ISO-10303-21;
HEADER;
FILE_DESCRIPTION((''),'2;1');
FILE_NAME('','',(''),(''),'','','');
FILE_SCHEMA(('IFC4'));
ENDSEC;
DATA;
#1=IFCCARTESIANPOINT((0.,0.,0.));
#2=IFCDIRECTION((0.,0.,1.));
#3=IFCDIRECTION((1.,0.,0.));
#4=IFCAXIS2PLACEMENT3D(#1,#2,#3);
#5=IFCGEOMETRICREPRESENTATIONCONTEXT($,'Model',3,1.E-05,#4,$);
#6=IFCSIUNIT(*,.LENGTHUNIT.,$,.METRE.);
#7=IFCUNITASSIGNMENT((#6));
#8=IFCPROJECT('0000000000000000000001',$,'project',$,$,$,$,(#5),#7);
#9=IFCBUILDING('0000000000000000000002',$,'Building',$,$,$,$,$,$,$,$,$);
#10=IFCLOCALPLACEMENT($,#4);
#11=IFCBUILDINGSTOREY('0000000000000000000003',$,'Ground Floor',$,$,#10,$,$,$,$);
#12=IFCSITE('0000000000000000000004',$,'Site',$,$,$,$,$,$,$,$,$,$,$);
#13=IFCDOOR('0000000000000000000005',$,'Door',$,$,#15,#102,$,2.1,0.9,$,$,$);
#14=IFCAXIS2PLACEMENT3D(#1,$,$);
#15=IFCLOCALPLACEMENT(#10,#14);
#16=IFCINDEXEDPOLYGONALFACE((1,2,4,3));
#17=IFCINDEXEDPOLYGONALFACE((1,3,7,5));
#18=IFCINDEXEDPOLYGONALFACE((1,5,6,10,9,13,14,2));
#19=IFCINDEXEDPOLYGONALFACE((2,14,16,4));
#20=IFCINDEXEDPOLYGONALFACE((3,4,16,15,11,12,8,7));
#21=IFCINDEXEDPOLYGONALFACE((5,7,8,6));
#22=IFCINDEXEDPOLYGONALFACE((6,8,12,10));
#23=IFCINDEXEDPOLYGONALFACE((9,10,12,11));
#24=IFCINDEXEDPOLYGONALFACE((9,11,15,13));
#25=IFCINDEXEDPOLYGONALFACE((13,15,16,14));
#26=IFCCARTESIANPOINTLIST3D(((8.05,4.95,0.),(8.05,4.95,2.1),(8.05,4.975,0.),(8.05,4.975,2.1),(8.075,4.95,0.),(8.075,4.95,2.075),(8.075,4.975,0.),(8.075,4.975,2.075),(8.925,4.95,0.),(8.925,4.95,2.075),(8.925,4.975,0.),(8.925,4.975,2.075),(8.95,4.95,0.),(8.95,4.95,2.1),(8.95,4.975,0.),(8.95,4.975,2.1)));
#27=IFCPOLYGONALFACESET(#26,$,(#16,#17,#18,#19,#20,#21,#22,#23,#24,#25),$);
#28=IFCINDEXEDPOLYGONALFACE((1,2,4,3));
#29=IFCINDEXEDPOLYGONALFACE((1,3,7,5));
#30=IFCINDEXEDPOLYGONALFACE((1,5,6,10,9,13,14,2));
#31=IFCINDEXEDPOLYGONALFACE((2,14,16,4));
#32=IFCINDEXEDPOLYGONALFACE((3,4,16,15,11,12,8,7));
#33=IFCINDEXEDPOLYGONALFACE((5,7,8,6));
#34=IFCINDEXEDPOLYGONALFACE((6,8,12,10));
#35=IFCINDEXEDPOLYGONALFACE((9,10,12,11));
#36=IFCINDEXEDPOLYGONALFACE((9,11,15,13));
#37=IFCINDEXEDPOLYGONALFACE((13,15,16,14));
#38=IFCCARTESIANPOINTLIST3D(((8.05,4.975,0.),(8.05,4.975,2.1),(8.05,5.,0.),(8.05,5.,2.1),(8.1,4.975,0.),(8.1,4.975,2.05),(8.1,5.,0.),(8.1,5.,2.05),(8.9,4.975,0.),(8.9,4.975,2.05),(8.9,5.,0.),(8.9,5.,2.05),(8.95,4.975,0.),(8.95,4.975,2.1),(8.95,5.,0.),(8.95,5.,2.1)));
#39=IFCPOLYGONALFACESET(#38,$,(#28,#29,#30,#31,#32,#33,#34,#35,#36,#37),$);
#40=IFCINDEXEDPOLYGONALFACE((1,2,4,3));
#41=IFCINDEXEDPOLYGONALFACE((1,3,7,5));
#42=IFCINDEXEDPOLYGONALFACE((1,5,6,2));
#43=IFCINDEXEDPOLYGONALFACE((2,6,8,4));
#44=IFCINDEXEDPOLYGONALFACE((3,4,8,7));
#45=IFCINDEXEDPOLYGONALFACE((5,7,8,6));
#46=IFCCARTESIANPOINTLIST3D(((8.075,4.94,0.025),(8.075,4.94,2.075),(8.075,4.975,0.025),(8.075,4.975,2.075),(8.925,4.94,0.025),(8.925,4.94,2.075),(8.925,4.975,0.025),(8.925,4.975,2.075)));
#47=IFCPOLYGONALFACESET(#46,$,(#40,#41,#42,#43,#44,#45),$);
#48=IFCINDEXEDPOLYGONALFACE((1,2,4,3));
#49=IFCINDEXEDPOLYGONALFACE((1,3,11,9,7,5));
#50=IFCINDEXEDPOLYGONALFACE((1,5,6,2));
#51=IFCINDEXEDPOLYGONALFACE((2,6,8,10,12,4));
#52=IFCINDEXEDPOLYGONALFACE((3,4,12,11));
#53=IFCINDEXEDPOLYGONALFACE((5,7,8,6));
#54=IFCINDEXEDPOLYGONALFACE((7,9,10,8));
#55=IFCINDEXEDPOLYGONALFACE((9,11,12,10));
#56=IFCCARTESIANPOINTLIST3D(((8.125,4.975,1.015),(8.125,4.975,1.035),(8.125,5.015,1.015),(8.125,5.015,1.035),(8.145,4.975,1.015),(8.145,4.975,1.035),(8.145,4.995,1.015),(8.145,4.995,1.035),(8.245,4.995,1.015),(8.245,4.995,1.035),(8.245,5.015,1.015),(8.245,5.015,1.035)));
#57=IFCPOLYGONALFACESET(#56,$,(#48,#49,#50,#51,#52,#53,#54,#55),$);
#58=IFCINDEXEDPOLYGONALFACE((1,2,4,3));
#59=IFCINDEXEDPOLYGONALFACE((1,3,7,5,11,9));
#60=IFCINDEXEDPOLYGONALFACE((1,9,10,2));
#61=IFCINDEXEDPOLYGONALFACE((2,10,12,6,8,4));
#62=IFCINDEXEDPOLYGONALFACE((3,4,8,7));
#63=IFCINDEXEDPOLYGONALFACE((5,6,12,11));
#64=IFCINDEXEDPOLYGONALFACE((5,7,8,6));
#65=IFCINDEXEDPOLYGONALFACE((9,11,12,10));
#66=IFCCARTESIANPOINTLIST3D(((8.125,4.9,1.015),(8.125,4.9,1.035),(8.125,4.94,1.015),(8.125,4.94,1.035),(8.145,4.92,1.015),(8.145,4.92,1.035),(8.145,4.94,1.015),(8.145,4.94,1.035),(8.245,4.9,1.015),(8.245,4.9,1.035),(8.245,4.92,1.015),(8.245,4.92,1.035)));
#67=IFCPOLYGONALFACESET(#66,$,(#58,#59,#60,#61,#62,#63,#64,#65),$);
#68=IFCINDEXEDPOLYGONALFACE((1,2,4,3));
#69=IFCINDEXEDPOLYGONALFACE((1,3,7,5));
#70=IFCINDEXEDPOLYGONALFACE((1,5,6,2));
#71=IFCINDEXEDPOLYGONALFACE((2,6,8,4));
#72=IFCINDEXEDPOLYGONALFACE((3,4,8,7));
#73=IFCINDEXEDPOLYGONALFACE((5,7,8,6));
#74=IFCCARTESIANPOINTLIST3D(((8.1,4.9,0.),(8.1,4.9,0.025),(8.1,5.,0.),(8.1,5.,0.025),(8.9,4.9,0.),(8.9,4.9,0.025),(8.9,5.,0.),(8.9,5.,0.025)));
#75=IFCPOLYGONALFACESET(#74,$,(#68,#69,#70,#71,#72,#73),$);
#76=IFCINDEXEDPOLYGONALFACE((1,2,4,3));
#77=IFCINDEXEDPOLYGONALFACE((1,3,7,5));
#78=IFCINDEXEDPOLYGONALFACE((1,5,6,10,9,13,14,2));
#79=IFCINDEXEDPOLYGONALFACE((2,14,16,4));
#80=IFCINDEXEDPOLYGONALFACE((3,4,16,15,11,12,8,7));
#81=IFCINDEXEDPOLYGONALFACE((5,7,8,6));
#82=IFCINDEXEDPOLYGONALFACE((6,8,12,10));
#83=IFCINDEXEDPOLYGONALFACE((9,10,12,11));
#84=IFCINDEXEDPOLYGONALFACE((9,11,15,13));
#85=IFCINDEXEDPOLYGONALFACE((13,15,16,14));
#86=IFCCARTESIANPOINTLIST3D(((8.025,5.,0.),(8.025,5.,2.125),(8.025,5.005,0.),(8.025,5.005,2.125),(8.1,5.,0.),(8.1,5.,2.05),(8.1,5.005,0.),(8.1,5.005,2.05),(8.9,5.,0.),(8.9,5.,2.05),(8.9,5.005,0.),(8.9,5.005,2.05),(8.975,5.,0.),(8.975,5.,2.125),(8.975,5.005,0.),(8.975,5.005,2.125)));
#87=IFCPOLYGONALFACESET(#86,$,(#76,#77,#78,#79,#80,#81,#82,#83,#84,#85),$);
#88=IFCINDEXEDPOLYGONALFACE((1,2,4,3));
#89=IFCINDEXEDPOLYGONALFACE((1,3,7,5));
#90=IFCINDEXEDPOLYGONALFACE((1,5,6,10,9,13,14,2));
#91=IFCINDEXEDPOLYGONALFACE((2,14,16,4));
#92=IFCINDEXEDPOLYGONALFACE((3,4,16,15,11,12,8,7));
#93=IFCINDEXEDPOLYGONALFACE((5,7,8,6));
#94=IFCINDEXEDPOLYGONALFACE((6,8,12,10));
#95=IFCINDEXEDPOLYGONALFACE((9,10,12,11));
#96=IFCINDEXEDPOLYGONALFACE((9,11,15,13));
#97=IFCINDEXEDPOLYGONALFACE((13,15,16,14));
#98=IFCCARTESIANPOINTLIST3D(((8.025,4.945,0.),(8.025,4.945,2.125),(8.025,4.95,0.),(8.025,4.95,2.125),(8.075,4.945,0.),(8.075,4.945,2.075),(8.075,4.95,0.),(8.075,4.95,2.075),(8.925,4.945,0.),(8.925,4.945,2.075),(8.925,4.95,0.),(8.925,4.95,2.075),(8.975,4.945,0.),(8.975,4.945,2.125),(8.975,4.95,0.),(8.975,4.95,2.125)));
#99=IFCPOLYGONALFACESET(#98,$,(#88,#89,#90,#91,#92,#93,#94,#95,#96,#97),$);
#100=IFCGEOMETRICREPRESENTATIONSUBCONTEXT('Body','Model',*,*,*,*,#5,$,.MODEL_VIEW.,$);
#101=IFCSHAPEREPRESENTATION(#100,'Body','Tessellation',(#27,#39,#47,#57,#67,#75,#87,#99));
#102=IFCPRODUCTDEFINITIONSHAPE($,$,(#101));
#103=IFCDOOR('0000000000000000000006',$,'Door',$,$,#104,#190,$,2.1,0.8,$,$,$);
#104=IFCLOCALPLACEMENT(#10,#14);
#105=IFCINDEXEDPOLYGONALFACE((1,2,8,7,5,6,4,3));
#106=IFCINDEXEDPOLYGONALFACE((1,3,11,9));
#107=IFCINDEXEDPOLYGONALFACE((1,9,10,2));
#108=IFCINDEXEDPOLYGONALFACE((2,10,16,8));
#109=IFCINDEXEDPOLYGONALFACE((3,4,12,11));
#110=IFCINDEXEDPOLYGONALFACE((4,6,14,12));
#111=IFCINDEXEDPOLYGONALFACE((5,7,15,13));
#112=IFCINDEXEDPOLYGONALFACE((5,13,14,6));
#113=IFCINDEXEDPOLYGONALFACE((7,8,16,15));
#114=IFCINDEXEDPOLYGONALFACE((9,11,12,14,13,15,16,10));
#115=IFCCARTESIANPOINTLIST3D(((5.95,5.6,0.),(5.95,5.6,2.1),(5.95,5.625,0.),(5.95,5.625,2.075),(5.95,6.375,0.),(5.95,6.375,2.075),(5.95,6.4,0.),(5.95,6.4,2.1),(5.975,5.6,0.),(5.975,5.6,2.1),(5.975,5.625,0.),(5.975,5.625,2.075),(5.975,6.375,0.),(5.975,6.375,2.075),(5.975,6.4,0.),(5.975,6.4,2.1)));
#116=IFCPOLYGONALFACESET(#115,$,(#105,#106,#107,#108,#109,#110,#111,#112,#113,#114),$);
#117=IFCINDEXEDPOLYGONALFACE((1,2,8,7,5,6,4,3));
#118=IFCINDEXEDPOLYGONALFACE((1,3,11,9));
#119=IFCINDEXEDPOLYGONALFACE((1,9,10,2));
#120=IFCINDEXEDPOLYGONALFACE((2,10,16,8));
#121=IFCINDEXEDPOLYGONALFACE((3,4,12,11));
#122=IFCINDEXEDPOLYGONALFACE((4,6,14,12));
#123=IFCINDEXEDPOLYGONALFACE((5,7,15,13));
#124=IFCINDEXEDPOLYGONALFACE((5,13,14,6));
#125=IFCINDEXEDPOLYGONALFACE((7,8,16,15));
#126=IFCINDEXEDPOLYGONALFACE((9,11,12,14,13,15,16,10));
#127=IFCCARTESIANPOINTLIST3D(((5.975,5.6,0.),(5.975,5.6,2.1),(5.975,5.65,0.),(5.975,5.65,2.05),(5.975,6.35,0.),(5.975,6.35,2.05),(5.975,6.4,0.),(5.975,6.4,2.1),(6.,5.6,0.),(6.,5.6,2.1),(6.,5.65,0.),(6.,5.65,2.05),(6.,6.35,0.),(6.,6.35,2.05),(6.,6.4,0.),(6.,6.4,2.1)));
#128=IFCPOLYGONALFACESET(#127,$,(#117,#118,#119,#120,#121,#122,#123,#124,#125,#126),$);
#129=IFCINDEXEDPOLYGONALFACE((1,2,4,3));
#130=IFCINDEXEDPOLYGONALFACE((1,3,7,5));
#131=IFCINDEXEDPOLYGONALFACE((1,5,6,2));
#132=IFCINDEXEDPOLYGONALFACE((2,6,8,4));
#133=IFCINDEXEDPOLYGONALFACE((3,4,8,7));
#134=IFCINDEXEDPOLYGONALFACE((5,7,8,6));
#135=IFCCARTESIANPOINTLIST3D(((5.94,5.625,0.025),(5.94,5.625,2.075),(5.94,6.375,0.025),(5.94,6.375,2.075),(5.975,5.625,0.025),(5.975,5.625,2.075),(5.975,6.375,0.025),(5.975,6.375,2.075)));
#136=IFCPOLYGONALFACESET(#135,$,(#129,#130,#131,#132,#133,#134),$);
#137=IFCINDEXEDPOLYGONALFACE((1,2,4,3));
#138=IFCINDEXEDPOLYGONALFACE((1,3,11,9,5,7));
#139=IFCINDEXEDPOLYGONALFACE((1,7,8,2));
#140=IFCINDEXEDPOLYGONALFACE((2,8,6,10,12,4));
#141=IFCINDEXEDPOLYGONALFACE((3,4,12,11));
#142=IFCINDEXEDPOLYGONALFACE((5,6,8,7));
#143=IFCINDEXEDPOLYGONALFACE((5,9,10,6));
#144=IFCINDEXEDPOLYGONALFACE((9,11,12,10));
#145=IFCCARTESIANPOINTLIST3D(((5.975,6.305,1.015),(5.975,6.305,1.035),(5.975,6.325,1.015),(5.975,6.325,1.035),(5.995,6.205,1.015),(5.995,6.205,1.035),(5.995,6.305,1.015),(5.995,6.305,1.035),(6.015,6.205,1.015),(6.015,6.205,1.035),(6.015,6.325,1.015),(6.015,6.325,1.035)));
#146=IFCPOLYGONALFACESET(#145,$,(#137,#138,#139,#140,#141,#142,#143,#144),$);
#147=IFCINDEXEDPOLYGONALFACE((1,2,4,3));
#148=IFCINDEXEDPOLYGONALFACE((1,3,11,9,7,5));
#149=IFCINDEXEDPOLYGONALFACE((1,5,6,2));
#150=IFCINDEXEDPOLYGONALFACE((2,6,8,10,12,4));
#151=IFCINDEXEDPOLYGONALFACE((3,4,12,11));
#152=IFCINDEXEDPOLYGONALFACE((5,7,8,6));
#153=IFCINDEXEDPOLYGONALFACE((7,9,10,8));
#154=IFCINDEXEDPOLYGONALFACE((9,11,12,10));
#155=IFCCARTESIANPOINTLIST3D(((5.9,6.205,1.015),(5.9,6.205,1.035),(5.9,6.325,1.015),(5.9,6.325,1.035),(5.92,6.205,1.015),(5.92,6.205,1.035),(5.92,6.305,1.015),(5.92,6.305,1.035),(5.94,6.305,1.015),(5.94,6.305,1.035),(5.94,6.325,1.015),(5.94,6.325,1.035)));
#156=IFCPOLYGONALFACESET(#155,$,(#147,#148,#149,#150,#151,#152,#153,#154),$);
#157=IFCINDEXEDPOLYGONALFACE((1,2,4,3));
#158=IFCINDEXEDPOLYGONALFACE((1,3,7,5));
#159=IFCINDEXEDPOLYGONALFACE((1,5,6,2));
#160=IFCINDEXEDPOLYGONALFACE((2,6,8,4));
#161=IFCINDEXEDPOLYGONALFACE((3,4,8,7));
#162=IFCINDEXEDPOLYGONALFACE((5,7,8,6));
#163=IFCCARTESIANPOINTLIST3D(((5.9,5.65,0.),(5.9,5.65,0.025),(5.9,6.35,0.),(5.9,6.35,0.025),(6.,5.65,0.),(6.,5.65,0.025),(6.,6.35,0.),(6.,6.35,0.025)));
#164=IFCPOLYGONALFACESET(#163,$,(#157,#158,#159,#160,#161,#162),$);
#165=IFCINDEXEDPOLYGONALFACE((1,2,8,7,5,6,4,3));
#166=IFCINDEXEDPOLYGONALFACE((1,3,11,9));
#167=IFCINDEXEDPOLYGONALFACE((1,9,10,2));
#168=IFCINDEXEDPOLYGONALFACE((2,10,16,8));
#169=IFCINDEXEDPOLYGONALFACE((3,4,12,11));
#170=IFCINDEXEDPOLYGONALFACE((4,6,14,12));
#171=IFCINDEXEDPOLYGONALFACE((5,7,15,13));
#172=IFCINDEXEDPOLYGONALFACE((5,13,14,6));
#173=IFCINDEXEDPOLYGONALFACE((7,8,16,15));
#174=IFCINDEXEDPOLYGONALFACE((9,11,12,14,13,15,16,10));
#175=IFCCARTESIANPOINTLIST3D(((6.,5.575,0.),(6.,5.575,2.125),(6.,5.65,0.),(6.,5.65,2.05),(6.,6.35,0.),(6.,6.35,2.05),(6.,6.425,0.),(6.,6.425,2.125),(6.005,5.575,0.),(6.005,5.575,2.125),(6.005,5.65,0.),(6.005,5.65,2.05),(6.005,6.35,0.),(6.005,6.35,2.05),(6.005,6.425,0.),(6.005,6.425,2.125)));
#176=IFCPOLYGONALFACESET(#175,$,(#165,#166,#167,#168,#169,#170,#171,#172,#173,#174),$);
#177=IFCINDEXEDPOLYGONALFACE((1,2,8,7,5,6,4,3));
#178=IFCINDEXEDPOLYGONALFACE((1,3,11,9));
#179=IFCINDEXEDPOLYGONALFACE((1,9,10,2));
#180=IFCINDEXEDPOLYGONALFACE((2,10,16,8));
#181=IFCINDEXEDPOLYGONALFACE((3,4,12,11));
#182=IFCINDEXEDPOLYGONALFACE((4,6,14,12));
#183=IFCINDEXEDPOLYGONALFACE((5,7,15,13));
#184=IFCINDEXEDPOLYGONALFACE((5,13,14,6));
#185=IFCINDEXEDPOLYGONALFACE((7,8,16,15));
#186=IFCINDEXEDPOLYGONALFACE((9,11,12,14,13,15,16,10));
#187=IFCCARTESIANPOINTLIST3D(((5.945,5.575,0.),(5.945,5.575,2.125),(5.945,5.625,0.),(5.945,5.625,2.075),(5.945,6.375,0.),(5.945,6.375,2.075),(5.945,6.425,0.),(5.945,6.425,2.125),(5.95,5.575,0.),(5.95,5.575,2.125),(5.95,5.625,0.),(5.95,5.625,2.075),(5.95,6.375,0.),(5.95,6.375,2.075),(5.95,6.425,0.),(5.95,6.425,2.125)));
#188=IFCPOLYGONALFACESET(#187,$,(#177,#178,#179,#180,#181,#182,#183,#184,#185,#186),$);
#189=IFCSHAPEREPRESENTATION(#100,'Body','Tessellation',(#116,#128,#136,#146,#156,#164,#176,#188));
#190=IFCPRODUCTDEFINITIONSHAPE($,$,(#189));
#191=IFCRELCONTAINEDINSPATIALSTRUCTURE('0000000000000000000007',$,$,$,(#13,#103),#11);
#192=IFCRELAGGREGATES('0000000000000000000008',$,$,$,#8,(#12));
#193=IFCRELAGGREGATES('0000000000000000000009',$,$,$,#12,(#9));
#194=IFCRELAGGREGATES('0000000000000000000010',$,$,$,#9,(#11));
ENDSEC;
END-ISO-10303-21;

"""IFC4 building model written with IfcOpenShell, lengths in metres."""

from ifc_helpers import new_model, si_unit, frame, origin_with_axes, place, context, subcontext, project, spatial, line, indexed_curve, outline, extrude, element, save


model = new_model("IFC4")

# Units and contexts
model_context = context("Model", 3, precision=1e-05, world=origin_with_axes())
body_context = subcontext(model_context, "Body", "Model", "MODEL_VIEW")
ifc_project = project(units=[si_unit("LENGTHUNIT", "METRE")], contexts=[model_context])

# Site, building, storey
site = spatial("IfcSite", under=ifc_project, Name="Site")
building = spatial("IfcBuilding", under=site, Name="Building")
storey_placement = place(None, origin_with_axes())
storey = spatial("IfcBuildingStorey", under=building, at=storey_placement, Name="Ground Floor")

# Doors
door_1_placement = place(storey_placement, frame((8.95, 5.0, 0.0), z_axis=(0.0, 0.0, 1.0), x_axis=(-1.0, 0.0, 0.0)))
element("IfcDoor", 1, at=door_1_placement, inside=storey, Name="Door", OverallHeight=2.1, OverallWidth=0.9, context=body_context, shape_type="SweptSolid", body=[
    extrude(outline(indexed_curve([(0.0, 0.0), (0.0, 2.1), (0.9, 2.1), (0.9, 0.0), (0.875, 0.0), (0.875, 2.075), (0.025, 2.075), (0.025, 0.0)], segments=[line(1, 2, 3, 4, 5, 6, 7, 8, 1)])), frame((0.0, 0.025, 0.0), z_axis=(0.0, -1.0, 0.0), x_axis=(1.0, 0.0, 0.0)), (0.0, 0.0, -1.0), 0.025),
    extrude(outline(indexed_curve([(0.0, 0.0), (0.0, 2.1), (0.9, 2.1), (0.9, 0.0), (0.85, 0.0), (0.85, 2.05), (0.05, 2.05), (0.05, 0.0)], segments=[line(1, 2, 3, 4, 5, 6, 7, 8, 1)])), frame((0.0, 0.0, 0.0), z_axis=(0.0, -1.0, 0.0), x_axis=(1.0, 0.0, 0.0)), (0.0, 0.0, -1.0), 0.025),
    extrude(outline(indexed_curve([(0.0, 0.0), (0.85, 0.0), (0.85, 0.035), (0.0, 0.035)], segments=[line(1, 2, 3, 4, 1)])), frame((0.025, 0.025, 0.025), z_axis=(0.0, 0.0, 1.0), x_axis=(1.0, 0.0, 0.0)), (0.0, 0.0, 1.0), 2.05),
    extrude(outline(indexed_curve([(0.0, 0.0), (0.0, -0.04), (-0.12, -0.04), (-0.12, -0.02), (-0.02, -0.02), (-0.02, 0.0)], segments=[line(1, 2, 3, 4, 5, 6, 1)])), frame((0.825, 0.025, 1.015), z_axis=(0.0, 0.0, 1.0), x_axis=(1.0, 0.0, 0.0)), (0.0, 0.0, 1.0), 0.02),
    extrude(outline(indexed_curve([(0.0, 0.0), (0.0, 0.04), (-0.12, 0.04), (-0.12, 0.02), (-0.02, 0.02), (-0.02, 0.0)], segments=[line(1, 2, 3, 4, 5, 6, 1)])), frame((0.825, 0.06, 1.015), z_axis=(0.0, 0.0, 1.0), x_axis=(1.0, 0.0, 0.0)), (0.0, 0.0, 1.0), 0.02),
    extrude(outline(indexed_curve([(0.0, 0.0), (0.8, 0.0), (0.8, 0.1), (0.0, 0.1)], segments=[line(1, 2, 3, 4, 1)])), frame((0.05, 0.0, 0.0), z_axis=(0.0, 0.0, 1.0), x_axis=(1.0, 0.0, 0.0)), (0.0, 0.0, 1.0), 0.025),
    extrude(outline(indexed_curve([(0.0, 0.0), (0.0, 2.125), (0.95, 2.125), (0.95, 0.0), (0.875, 0.0), (0.875, 2.05), (0.075, 2.05), (0.075, 0.0)], segments=[line(1, 2, 3, 4, 5, 6, 7, 8, 1)])), frame((-0.025, -0.005, 0.0), z_axis=(0.0, -1.0, 0.0), x_axis=(1.0, 0.0, 0.0)), (0.0, 0.0, -1.0), 0.005),
    extrude(outline(indexed_curve([(0.0, 0.0), (0.0, 2.125), (0.95, 2.125), (0.95, 0.0), (0.9, 0.0), (0.9, 2.075), (0.05, 2.075), (0.05, 0.0)], segments=[line(1, 2, 3, 4, 5, 6, 7, 8, 1)])), frame((-0.025, 0.05, 0.0), z_axis=(0.0, -1.0, 0.0), x_axis=(1.0, 0.0, 0.0)), (0.0, 0.0, -1.0), 0.005),
])
door_2_placement = place(storey_placement, frame((6.0, 5.6, 0.0), z_axis=(0.0, 0.0, 1.0), x_axis=(0.0, 1.0, 0.0)))
element("IfcDoor", 2, at=door_2_placement, inside=storey, Name="Door", OverallHeight=2.1, OverallWidth=0.8, context=body_context, shape_type="SweptSolid", body=[
    extrude(outline(indexed_curve([(0.0, 0.0), (0.0, 2.1), (0.8, 2.1), (0.8, 0.0), (0.775, 0.0), (0.775, 2.075), (0.025, 2.075), (0.025, 0.0)], segments=[line(1, 2, 3, 4, 5, 6, 7, 8, 1)])), frame((0.0, 0.025, 0.0), z_axis=(0.0, -1.0, 0.0), x_axis=(1.0, 0.0, 0.0)), (0.0, 0.0, -1.0), 0.025),
    extrude(outline(indexed_curve([(0.0, 0.0), (0.0, 2.1), (0.8, 2.1), (0.8, 0.0), (0.75, 0.0), (0.75, 2.05), (0.05, 2.05), (0.05, 0.0)], segments=[line(1, 2, 3, 4, 5, 6, 7, 8, 1)])), frame((0.0, 0.0, 0.0), z_axis=(0.0, -1.0, 0.0), x_axis=(1.0, 0.0, 0.0)), (0.0, 0.0, -1.0), 0.025),
    extrude(outline(indexed_curve([(0.0, 0.0), (0.75, 0.0), (0.75, 0.035), (0.0, 0.035)], segments=[line(1, 2, 3, 4, 1)])), frame((0.025, 0.025, 0.025), z_axis=(0.0, 0.0, 1.0), x_axis=(1.0, 0.0, 0.0)), (0.0, 0.0, 1.0), 2.05),
    extrude(outline(indexed_curve([(0.0, 0.0), (0.0, -0.04), (-0.12, -0.04), (-0.12, -0.02), (-0.02, -0.02), (-0.02, 0.0)], segments=[line(1, 2, 3, 4, 5, 6, 1)])), frame((0.725, 0.025, 1.015), z_axis=(0.0, 0.0, 1.0), x_axis=(1.0, 0.0, 0.0)), (0.0, 0.0, 1.0), 0.02),
    extrude(outline(indexed_curve([(0.0, 0.0), (0.0, 0.04), (-0.12, 0.04), (-0.12, 0.02), (-0.02, 0.02), (-0.02, 0.0)], segments=[line(1, 2, 3, 4, 5, 6, 1)])), frame((0.725, 0.06, 1.015), z_axis=(0.0, 0.0, 1.0), x_axis=(1.0, 0.0, 0.0)), (0.0, 0.0, 1.0), 0.02),
    extrude(outline(indexed_curve([(0.0, 0.0), (0.7, 0.0), (0.7, 0.1), (0.0, 0.1)], segments=[line(1, 2, 3, 4, 1)])), frame((0.05, 0.0, 0.0), z_axis=(0.0, 0.0, 1.0), x_axis=(1.0, 0.0, 0.0)), (0.0, 0.0, 1.0), 0.025),
    extrude(outline(indexed_curve([(0.0, 0.0), (0.0, 2.125), (0.85, 2.125), (0.85, 0.0), (0.775, 0.0), (0.775, 2.05), (0.075, 2.05), (0.075, 0.0)], segments=[line(1, 2, 3, 4, 5, 6, 7, 8, 1)])), frame((-0.025, -0.005, 0.0), z_axis=(0.0, -1.0, 0.0), x_axis=(1.0, 0.0, 0.0)), (0.0, 0.0, -1.0), 0.005),
    extrude(outline(indexed_curve([(0.0, 0.0), (0.0, 2.125), (0.85, 2.125), (0.85, 0.0), (0.8, 0.0), (0.8, 2.075), (0.05, 2.075), (0.05, 0.0)], segments=[line(1, 2, 3, 4, 5, 6, 7, 8, 1)])), frame((-0.025, 0.05, 0.0), z_axis=(0.0, -1.0, 0.0), x_axis=(1.0, 0.0, 0.0)), (0.0, 0.0, -1.0), 0.005),
])

save(model, "model.ifc")
